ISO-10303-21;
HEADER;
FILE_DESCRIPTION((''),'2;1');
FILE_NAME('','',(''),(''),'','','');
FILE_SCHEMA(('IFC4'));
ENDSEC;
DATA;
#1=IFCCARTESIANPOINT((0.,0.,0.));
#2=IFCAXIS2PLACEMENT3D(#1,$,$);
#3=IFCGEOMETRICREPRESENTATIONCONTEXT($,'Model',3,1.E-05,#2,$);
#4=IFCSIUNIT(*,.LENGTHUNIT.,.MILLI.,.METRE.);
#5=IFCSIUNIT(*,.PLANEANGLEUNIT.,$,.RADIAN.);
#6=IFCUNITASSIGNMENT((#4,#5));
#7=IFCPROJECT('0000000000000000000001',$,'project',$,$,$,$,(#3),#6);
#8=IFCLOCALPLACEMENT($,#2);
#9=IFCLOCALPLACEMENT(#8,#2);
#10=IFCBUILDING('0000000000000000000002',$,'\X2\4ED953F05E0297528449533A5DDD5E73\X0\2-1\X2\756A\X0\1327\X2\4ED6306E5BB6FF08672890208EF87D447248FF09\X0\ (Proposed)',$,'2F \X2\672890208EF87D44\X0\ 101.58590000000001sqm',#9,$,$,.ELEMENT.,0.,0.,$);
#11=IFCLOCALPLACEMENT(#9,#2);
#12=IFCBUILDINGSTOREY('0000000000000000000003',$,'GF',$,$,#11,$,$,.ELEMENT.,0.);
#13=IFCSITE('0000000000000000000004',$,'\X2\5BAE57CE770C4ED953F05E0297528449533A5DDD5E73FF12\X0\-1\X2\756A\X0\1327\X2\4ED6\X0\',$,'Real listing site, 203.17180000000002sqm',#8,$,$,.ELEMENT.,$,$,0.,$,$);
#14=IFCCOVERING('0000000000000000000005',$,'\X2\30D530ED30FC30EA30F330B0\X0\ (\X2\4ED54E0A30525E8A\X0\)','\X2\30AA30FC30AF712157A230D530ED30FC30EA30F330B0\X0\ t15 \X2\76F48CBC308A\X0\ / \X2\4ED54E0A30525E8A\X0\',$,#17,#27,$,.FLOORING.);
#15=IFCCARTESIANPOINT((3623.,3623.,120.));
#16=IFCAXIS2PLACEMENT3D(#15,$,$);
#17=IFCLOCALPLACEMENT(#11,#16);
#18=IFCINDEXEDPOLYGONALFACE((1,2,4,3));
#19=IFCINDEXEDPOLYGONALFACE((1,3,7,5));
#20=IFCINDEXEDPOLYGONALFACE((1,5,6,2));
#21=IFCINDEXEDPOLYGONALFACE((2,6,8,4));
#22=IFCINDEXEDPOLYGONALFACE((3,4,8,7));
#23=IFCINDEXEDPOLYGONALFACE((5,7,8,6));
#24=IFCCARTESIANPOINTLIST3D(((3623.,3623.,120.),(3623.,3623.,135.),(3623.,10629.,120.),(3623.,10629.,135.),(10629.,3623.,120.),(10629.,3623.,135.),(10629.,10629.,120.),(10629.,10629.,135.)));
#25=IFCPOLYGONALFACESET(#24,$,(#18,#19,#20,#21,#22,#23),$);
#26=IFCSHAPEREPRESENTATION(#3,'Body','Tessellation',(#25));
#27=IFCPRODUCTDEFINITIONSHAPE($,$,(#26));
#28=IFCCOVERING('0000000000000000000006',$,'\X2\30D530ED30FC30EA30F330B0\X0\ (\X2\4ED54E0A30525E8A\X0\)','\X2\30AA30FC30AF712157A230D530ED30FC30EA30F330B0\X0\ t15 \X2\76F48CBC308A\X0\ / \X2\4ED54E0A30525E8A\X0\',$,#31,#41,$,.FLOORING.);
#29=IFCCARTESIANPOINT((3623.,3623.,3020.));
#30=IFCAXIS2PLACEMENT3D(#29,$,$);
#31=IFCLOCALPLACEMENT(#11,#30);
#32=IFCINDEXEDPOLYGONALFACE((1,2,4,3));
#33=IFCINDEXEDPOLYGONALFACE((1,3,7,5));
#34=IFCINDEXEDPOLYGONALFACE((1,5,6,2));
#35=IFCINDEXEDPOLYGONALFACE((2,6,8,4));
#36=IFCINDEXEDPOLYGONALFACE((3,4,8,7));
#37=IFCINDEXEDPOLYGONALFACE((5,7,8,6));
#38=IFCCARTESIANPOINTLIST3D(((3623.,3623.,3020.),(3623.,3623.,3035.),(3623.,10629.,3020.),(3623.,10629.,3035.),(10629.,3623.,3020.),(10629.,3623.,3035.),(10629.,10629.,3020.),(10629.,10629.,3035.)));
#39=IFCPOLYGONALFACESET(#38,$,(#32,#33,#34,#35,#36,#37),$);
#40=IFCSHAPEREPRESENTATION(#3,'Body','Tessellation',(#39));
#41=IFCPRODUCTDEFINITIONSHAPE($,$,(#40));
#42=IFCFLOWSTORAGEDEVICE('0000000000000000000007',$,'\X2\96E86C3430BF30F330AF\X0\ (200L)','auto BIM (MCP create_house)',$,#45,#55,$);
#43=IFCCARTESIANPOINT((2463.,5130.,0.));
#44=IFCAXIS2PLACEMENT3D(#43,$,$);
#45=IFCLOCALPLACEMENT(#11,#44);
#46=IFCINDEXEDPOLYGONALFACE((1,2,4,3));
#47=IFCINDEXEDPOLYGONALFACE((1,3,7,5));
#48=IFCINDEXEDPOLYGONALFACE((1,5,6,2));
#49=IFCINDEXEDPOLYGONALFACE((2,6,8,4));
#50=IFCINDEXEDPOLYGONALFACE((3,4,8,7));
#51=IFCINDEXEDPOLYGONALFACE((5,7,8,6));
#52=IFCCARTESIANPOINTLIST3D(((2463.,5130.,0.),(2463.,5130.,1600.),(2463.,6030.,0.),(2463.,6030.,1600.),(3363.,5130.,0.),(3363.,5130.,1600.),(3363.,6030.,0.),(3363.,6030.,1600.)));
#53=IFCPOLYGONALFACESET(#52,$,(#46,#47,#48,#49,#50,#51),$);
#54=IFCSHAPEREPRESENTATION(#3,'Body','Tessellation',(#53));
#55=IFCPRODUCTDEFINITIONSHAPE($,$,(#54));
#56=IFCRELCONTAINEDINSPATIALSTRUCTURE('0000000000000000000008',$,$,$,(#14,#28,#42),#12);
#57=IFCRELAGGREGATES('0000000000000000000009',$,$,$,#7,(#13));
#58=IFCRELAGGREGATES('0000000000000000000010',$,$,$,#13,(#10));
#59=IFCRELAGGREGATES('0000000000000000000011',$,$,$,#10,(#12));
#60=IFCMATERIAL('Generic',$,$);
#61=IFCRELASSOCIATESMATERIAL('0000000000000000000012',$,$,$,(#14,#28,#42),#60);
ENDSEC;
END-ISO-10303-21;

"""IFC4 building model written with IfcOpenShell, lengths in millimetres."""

from ifc_helpers import new_model, si_unit, frame, frame_2d, origin, place, context, project, spatial, rectangle, extrude, material, element, save


model = new_model("IFC4")

# Units and contexts
model_context = context("Model", 3, precision=1e-05, world=origin())
ifc_project = project(units=[si_unit("LENGTHUNIT", "METRE", prefix="MILLI"), si_unit("PLANEANGLEUNIT", "RADIAN")], contexts=[model_context])

# Site, building, storey
site_placement = place(None, origin())
site = spatial("IfcSite", under=ifc_project, at=site_placement, Name="宮城県仙台市青葉区川平２-1番1327他", ObjectType="Real listing site, 203.17180000000002sqm", CompositionType="ELEMENT", RefElevation=0.0)
building_placement = place(site_placement, origin())
building = spatial("IfcBuilding", under=site, at=building_placement, Name="仙台市青葉区川平2-1番1327他の家（木造軸組版） (Proposed)", ObjectType="2F 木造軸組 101.58590000000001sqm", CompositionType="ELEMENT", ElevationOfRefHeight=0.0, ElevationOfTerrain=0.0)
storey_placement = place(building_placement, origin())
storey = spatial("IfcBuildingStorey", under=building, at=storey_placement, Name="GF", CompositionType="ELEMENT", Elevation=0.0)

# Coverings
ifc_material_1 = material(Name="Generic")
covering_1_placement = place(storey_placement, frame((3623.0, 3623.0, 120.0)))
element("IfcCovering", 1, at=covering_1_placement, inside=storey, material=ifc_material_1, Name="フローリング (仕上げ床)", Description="オーク無垢フローリング t15 直貼り / 仕上げ床", PredefinedType="FLOORING", context=model_context, shape_type="SweptSolid", body=[
    extrude(rectangle(XDim=7006.0, YDim=7006.0, at=frame_2d((3503.0, 3503.0))), frame((3623.0, 3623.0, 120.0)), (0.0, 0.0, 1.0), 15.0),
])
covering_2_placement = place(storey_placement, frame((3623.0, 3623.0, 3020.0)))
element("IfcCovering", 2, at=covering_2_placement, inside=storey, material=ifc_material_1, Name="フローリング (仕上げ床)", Description="オーク無垢フローリング t15 直貼り / 仕上げ床", PredefinedType="FLOORING", context=model_context, shape_type="SweptSolid", body=[
    extrude(rectangle(XDim=7006.0, YDim=7006.0, at=frame_2d((3503.0, 3503.0))), frame((3623.0, 3623.0, 3020.0)), (0.0, 0.0, 1.0), 15.0),
])

# Flow storage device
flow_storage_device_placement = place(storey_placement, frame((2463.0, 5130.0, 0.0)))
element("IfcFlowStorageDevice", 3, at=flow_storage_device_placement, inside=storey, material=ifc_material_1, Name="雨水タンク (200L)", Description="auto BIM (MCP create_house)", context=model_context, shape_type="SweptSolid", body=[
    extrude(rectangle(XDim=900.0, YDim=900.0, at=frame_2d((450.0, 450.0))), frame((2463.0, 5130.0, 0.0)), (0.0, 0.0, 1.0), 1600.0),
])

save(model, "model.ifc")
